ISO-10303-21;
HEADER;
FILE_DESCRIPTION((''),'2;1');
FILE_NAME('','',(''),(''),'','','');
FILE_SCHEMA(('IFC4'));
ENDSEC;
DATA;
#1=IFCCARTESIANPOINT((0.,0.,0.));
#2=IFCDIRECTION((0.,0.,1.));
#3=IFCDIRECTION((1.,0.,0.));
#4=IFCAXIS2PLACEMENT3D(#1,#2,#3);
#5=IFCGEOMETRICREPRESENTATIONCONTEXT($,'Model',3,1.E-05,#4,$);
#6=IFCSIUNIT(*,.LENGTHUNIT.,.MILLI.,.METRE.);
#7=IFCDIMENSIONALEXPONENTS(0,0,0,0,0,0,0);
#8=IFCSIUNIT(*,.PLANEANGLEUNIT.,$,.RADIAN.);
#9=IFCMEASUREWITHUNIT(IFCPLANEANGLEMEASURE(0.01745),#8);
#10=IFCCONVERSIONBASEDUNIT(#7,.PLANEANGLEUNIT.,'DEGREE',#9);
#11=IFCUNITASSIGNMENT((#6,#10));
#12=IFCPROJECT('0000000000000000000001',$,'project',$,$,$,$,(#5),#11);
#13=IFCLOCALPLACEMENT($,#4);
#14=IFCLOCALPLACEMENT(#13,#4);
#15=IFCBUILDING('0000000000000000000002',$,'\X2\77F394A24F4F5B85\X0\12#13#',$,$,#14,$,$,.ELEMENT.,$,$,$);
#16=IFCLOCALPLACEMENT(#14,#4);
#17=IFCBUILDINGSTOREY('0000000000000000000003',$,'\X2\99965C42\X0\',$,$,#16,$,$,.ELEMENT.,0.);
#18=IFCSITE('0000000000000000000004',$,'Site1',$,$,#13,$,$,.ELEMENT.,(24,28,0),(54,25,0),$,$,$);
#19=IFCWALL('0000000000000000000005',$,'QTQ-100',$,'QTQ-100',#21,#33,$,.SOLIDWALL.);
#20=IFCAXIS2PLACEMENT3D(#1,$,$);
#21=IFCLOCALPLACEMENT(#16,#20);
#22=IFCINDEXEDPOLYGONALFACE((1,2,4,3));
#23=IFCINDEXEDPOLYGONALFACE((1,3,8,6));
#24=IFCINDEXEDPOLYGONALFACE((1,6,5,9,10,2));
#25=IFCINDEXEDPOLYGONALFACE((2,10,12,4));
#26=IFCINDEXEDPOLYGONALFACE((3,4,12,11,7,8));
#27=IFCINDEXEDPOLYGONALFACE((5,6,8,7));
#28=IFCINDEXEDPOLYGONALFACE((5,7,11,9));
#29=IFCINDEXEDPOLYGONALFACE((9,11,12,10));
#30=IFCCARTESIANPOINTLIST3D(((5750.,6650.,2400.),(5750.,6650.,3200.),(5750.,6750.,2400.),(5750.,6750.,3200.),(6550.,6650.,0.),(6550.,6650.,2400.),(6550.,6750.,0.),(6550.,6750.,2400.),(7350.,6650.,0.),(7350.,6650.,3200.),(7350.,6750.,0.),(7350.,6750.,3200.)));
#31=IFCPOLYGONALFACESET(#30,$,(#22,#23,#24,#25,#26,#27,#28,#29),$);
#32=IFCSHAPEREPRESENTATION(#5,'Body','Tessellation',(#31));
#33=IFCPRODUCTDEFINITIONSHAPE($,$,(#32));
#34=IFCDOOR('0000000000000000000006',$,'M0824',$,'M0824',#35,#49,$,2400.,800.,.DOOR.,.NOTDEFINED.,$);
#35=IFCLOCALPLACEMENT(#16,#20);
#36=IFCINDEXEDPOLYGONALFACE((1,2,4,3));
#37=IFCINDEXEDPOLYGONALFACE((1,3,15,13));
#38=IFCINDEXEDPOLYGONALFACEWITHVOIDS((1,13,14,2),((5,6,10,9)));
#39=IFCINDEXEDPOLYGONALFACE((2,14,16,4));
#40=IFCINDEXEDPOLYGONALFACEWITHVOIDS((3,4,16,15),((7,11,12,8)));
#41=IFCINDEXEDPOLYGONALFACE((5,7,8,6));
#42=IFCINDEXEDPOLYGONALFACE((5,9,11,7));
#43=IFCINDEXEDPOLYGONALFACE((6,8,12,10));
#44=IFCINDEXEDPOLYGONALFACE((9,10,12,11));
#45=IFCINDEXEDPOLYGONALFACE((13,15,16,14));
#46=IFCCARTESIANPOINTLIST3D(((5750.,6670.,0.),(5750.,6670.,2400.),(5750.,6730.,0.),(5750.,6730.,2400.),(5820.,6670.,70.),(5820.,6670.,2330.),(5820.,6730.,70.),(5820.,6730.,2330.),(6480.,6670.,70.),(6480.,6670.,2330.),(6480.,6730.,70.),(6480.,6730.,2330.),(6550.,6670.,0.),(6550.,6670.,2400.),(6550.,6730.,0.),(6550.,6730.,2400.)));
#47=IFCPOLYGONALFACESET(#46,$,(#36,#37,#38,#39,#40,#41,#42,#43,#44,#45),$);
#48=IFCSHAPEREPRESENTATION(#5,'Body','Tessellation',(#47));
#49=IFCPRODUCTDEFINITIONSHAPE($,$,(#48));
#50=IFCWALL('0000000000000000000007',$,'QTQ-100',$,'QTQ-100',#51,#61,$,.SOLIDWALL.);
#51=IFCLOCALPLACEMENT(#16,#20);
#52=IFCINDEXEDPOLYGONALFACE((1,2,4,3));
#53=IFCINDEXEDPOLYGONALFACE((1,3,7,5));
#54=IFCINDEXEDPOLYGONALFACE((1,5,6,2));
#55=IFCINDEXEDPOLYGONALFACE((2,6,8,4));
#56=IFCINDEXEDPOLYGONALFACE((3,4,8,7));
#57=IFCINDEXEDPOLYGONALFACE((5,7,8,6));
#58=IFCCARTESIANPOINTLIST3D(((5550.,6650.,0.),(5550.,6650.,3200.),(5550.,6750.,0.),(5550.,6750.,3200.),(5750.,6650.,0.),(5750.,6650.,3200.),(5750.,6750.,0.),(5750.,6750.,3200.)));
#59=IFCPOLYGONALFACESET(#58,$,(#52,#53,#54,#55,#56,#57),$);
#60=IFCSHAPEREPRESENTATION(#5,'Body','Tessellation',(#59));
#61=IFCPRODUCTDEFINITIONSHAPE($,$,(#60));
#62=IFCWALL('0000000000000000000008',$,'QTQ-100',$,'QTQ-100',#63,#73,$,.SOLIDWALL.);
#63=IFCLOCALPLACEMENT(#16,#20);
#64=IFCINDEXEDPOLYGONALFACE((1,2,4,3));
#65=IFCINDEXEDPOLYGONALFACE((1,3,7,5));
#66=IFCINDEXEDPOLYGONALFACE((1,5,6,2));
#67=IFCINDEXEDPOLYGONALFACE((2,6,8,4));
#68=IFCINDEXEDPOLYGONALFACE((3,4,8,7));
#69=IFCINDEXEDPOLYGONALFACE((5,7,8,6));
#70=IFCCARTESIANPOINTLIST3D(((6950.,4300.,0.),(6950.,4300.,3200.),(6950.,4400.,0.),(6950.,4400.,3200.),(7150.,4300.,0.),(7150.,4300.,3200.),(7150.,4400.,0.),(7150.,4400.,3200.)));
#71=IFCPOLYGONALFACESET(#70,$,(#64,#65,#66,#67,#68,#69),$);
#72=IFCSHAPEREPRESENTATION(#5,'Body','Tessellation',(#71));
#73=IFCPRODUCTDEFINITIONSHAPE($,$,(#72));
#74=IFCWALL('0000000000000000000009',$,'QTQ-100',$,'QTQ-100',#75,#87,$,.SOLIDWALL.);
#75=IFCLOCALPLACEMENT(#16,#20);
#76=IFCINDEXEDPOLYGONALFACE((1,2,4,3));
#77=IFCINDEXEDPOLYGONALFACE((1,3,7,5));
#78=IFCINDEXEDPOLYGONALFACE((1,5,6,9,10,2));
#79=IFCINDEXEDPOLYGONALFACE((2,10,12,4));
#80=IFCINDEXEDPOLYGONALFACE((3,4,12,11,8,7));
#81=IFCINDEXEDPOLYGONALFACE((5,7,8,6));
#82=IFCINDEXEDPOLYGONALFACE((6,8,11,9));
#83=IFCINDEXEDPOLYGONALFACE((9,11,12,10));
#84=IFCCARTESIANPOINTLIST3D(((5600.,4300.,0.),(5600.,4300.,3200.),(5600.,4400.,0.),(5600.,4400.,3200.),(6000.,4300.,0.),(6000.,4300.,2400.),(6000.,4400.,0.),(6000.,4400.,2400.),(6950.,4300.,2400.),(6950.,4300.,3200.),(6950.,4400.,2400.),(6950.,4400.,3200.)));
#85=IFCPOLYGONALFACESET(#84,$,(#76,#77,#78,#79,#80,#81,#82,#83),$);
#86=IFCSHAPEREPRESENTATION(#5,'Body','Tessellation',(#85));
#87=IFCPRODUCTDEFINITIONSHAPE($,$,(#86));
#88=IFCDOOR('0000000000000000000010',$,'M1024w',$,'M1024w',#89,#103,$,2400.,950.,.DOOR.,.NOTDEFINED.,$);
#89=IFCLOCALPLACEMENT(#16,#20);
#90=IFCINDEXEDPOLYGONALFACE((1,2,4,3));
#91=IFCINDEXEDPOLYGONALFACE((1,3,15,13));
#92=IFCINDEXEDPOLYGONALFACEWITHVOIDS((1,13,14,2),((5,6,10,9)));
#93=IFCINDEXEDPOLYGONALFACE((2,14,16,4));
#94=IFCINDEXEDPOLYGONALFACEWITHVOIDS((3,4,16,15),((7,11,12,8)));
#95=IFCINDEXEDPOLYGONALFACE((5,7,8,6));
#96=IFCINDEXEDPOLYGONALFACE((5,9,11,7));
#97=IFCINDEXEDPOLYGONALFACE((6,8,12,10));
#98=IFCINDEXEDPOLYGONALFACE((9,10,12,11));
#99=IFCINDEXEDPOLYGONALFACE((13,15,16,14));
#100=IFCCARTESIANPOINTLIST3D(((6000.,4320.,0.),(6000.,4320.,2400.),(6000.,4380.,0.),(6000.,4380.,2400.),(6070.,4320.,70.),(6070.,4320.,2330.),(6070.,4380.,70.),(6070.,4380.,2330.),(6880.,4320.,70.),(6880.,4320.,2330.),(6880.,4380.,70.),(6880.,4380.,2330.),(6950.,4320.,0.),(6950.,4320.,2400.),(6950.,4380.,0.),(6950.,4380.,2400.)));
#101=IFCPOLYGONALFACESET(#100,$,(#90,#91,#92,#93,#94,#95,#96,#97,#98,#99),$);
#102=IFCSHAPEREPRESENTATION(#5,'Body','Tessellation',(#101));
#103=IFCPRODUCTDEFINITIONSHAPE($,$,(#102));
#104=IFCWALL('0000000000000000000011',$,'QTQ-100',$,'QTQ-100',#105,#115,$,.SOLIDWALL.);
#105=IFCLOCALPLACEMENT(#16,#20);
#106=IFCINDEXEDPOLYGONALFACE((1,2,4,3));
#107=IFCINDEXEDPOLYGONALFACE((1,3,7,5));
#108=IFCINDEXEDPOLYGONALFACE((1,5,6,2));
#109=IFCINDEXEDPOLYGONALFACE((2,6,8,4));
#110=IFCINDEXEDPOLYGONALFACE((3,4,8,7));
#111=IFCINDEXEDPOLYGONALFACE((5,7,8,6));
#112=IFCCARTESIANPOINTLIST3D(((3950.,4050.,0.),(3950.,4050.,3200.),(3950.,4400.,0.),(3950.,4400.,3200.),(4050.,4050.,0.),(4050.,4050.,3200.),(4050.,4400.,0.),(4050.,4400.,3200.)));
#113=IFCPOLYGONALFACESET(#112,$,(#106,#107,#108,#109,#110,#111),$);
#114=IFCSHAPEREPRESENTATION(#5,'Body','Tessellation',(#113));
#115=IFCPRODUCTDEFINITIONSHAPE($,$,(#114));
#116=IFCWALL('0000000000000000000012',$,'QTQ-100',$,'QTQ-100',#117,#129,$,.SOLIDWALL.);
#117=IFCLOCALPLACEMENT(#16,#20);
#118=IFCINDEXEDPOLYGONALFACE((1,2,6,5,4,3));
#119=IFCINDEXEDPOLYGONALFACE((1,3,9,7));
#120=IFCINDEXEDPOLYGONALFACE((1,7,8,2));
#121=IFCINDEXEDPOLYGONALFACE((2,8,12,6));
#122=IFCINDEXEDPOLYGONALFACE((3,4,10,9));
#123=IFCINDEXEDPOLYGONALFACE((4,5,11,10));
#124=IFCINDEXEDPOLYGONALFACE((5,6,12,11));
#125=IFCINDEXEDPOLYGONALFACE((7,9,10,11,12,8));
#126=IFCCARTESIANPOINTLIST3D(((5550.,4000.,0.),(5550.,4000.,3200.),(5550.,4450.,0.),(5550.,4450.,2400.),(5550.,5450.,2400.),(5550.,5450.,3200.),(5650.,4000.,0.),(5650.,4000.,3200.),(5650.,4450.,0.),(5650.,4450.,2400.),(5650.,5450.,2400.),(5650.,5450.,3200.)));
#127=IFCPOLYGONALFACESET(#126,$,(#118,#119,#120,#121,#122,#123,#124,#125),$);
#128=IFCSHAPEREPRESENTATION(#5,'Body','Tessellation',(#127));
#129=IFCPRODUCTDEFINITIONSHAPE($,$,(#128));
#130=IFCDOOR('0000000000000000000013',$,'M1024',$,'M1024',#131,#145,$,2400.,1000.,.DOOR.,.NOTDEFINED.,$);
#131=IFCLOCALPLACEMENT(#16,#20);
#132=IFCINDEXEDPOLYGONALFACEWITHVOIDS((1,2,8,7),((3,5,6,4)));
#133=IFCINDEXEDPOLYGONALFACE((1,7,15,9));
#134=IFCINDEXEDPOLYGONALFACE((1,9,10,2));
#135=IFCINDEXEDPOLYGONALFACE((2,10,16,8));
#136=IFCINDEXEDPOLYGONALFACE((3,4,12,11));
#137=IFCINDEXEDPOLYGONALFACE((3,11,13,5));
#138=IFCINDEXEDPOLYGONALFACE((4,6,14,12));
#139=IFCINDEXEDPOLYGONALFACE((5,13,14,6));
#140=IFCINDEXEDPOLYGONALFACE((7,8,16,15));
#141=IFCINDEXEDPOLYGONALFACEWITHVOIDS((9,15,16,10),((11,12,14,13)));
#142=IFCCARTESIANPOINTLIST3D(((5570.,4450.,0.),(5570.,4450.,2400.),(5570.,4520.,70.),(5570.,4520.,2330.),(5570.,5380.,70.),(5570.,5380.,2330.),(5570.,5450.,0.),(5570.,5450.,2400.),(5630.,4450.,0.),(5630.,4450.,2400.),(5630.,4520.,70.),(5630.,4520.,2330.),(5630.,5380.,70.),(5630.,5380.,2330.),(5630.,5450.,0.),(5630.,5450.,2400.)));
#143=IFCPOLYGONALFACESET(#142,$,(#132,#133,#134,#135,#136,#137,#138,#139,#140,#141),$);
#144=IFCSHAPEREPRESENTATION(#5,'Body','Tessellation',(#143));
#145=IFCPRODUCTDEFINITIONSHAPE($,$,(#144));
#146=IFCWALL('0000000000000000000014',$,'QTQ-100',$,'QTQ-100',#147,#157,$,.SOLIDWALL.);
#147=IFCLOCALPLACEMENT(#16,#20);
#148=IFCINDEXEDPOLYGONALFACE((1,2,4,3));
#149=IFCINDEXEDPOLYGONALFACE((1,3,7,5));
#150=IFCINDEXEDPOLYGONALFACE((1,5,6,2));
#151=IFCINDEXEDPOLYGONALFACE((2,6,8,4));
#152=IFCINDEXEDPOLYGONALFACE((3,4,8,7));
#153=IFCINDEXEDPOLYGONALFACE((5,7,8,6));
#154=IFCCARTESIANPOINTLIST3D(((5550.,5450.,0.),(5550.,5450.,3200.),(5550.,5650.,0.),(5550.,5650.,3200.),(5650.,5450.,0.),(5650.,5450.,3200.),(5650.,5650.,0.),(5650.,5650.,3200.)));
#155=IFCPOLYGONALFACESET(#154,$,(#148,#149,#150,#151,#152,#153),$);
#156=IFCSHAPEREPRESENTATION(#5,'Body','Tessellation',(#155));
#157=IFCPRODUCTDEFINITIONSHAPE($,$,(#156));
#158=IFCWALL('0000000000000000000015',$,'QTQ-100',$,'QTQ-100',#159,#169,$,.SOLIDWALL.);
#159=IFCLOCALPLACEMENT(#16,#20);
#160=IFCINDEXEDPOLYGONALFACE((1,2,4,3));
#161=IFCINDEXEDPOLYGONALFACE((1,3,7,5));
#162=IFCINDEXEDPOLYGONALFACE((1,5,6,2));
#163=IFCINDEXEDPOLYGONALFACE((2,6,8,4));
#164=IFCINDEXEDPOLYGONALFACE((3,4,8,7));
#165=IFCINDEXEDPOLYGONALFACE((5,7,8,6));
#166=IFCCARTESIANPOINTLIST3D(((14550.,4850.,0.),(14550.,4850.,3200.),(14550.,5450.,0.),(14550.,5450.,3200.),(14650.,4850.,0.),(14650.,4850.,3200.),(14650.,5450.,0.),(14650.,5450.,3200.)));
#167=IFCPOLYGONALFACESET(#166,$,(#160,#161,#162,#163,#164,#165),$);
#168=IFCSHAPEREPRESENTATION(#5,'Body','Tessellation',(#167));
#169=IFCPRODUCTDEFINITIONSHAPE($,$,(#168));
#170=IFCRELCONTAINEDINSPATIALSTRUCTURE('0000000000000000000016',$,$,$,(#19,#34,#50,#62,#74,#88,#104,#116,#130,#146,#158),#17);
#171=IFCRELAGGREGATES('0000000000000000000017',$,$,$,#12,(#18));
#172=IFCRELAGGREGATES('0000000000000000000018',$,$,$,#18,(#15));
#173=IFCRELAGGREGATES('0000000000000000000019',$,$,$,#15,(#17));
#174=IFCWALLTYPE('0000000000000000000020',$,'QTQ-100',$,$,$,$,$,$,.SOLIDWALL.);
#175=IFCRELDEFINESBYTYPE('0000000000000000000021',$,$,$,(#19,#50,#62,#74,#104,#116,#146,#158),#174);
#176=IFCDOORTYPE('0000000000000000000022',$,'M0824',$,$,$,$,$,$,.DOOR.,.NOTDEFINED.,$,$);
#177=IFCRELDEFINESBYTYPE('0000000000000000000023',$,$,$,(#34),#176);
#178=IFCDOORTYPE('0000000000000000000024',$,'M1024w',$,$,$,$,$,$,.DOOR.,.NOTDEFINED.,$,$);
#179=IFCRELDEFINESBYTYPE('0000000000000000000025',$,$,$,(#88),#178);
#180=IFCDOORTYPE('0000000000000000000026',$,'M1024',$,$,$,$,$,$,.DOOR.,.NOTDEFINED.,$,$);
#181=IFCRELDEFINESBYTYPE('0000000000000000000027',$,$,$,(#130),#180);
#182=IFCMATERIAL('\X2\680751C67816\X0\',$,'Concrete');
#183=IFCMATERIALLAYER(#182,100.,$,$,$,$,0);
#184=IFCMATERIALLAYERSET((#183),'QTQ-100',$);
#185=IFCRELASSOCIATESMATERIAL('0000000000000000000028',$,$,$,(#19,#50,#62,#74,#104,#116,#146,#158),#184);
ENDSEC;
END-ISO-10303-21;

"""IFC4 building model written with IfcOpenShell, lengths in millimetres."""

from ifc_helpers import new_model, entity, si_unit, converted_unit, frame, origin_with_axes, place, context, project, spatial, polyline, outline, extrude, material, layer, layer_set, type_object, element, fill, save


model = new_model("IFC4")

# Units and contexts
model_context = context("Model", 3, precision=1e-05, world=origin_with_axes())
ifc_project = project(units=[si_unit("LENGTHUNIT", "METRE", prefix="MILLI"), converted_unit("PLANEANGLEUNIT", "DEGREE", entity("IfcPlaneAngleMeasure", 0.01745), si_unit("PLANEANGLEUNIT", "RADIAN"), dimensions=[0, 0, 0, 0, 0, 0, 0])], contexts=[model_context])

# Site, building, storey
site_placement = place(None, origin_with_axes())
site = spatial("IfcSite", under=ifc_project, at=site_placement, Name="Site1", CompositionType="ELEMENT", RefLatitude=(24, 28, 0), RefLongitude=(54, 25, 0))
building_placement = place(site_placement, origin_with_axes())
building = spatial("IfcBuilding", under=site, at=building_placement, Name="石钢住宅12#13#", CompositionType="ELEMENT")
storey_placement = place(building_placement, origin_with_axes())
storey = spatial("IfcBuildingStorey", under=building, at=storey_placement, Name="首层", CompositionType="ELEMENT", Elevation=0.0)

# Shared definitions
ifc_material = material(Name="标准砖", Category="Concrete")
ifc_layer = layer(ifc_material, 100.0, Priority=0)
ifc_layer_set = layer_set([ifc_layer], Name="QTQ-100")
wall_type = type_object("IfcWallType", Name="QTQ-100", PredefinedType="SOLIDWALL")

# Wall, opening, door
wall_1_placement = place(storey_placement, origin_with_axes())
wall_1 = element("IfcWall", 1, at=wall_1_placement, inside=storey, type_object=wall_type, material=ifc_layer_set, Name="QTQ-100", ObjectType="QTQ-100", PredefinedType="SOLIDWALL", context=model_context, shape_type="SweptSolid", body=[
    extrude(outline(polyline([(0.0, 0.0), (3200.0, 0.0), (3200.0, 1600.0), (0.0, 1600.0), (0.0, 0.0)])), frame((5750.0, 6750.0, 3200.0), z_axis=(0.0, -1.0, 0.0), x_axis=(0.0, 0.0, -1.0)), (0.0, 0.0, 1.0), 100.0),
])
opening_1_placement = place(storey_placement, origin_with_axes())
opening_1 = element("IfcOpeningElement", 2, at=opening_1_placement, cuts=wall_1, PredefinedType="OPENING", context=model_context, shape_type="SweptSolid", body=[
    extrude(outline(polyline([(0.0, 0.0), (800.0, 0.0), (800.0, 2400.0), (0.0, 2400.0), (0.0, 0.0)])), frame((5750.0, 7750.0, 0.0), z_axis=(0.0, -1.0, 0.0), x_axis=(1.0, 0.0, 0.0)), (0.0, 0.0, 1.0), 2100.0),
])
door_type_1 = type_object("IfcDoorType", Name="M0824", OperationType="NOTDEFINED", PredefinedType="DOOR")
door_1_placement = place(storey_placement, origin_with_axes())
door_1 = element("IfcDoor", 3, at=door_1_placement, inside=storey, type_object=door_type_1, Name="M0824", ObjectType="M0824", OperationType="NOTDEFINED", OverallHeight=2400.0, OverallWidth=800.0, PredefinedType="DOOR", context=model_context, shape_type="SweptSolid", body=[
    extrude(outline(polyline([(-400.0, -1200.0), (400.0, -1200.0), (400.0, 1200.0), (-400.0, 1200.0), (-400.0, -1200.0)]), holes=[polyline([(-330.0, -1130.0), (-330.0, 1130.0), (330.0, 1130.0), (330.0, -1130.0), (-330.0, -1130.0)])]), frame((6150.0, 6730.0, 1200.0), z_axis=(0.0, -1.0, 0.0), x_axis=(1.0, 0.0, 0.0)), (0.0, 0.0, 1.0), 60.0),
])
fill(opening_1, door_1)

# Walls
wall_2_placement = place(storey_placement, origin_with_axes())
element("IfcWall", 4, at=wall_2_placement, inside=storey, type_object=wall_type, material=ifc_layer_set, Name="QTQ-100", ObjectType="QTQ-100", PredefinedType="SOLIDWALL", context=model_context, shape_type="SweptSolid", body=[
    extrude(outline(polyline([(0.0, 0.0), (3200.0, 0.0), (3200.0, 200.0), (0.0, 200.0), (0.0, 0.0)])), frame((5550.0, 6750.0, 3200.0), z_axis=(0.0, -1.0, 0.0), x_axis=(0.0, 0.0, -1.0)), (0.0, 0.0, 1.0), 100.0),
])
wall_3_placement = place(storey_placement, origin_with_axes())
element("IfcWall", 5, at=wall_3_placement, inside=storey, type_object=wall_type, material=ifc_layer_set, Name="QTQ-100", ObjectType="QTQ-100", PredefinedType="SOLIDWALL", context=model_context, shape_type="SweptSolid", body=[
    extrude(outline(polyline([(0.0, 0.0), (3200.0, 0.0), (3200.0, 200.0), (0.0, 200.0), (0.0, 0.0)])), frame((6950.0, 4400.0, 3200.0), z_axis=(0.0, -1.0, 0.0), x_axis=(0.0, 0.0, -1.0)), (0.0, 0.0, 1.0), 100.0),
])

# Wall, opening, door
wall_4_placement = place(storey_placement, origin_with_axes())
wall_4 = element("IfcWall", 6, at=wall_4_placement, inside=storey, type_object=wall_type, material=ifc_layer_set, Name="QTQ-100", ObjectType="QTQ-100", PredefinedType="SOLIDWALL", context=model_context, shape_type="SweptSolid", body=[
    extrude(outline(polyline([(0.0, 0.0), (3200.0, 0.0), (3200.0, 1350.0), (0.0, 1350.0), (0.0, 0.0)])), frame((5600.0, 4400.0, 3200.0), z_axis=(0.0, -1.0, 0.0), x_axis=(0.0, 0.0, -1.0)), (0.0, 0.0, 1.0), 100.0),
])
opening_2_placement = place(storey_placement, origin_with_axes())
opening_2 = element("IfcOpeningElement", 7, at=opening_2_placement, cuts=wall_4, PredefinedType="OPENING", context=model_context, shape_type="SweptSolid", body=[
    extrude(outline(polyline([(0.0, 0.0), (950.0, 0.0), (950.0, 2400.0), (0.0, 2400.0), (0.0, 0.0)])), frame((6000.0, 5400.0, 0.0), z_axis=(0.0, -1.0, 0.0), x_axis=(1.0, 0.0, 0.0)), (0.0, 0.0, 1.0), 2100.0),
])
door_type_2 = type_object("IfcDoorType", Name="M1024w", OperationType="NOTDEFINED", PredefinedType="DOOR")
door_2_placement = place(storey_placement, origin_with_axes())
door_2 = element("IfcDoor", 8, at=door_2_placement, inside=storey, type_object=door_type_2, Name="M1024w", ObjectType="M1024w", OperationType="NOTDEFINED", OverallHeight=2400.0, OverallWidth=950.0, PredefinedType="DOOR", context=model_context, shape_type="SweptSolid", body=[
    extrude(outline(polyline([(-475.0, -1200.0), (475.0, -1200.0), (475.0, 1200.0), (-475.0, 1200.0), (-475.0, -1200.0)]), holes=[polyline([(-405.0, -1130.0), (-405.0, 1130.0), (405.0, 1130.0), (405.0, -1130.0), (-405.0, -1130.0)])]), frame((6475.0, 4380.0, 1200.0), z_axis=(0.0, -1.0, 0.0), x_axis=(1.0, 0.0, 0.0)), (0.0, 0.0, 1.0), 60.0),
])
fill(opening_2, door_2)

# Wall
wall_5_placement = place(storey_placement, origin_with_axes())
element("IfcWall", 9, at=wall_5_placement, inside=storey, type_object=wall_type, material=ifc_layer_set, Name="QTQ-100", ObjectType="QTQ-100", PredefinedType="SOLIDWALL", context=model_context, shape_type="SweptSolid", body=[
    extrude(outline(polyline([(0.0, 0.0), (3200.0, 0.0), (3200.0, 350.0), (0.0, 350.0), (0.0, 0.0)])), frame((3950.0, 4050.0, 3200.0), z_axis=(1.0, 0.0, 0.0), x_axis=(0.0, 0.0, -1.0)), (0.0, 0.0, 1.0), 100.0),
])

# Wall, opening, door
wall_6_placement = place(storey_placement, origin_with_axes())
wall_6 = element("IfcWall", 10, at=wall_6_placement, inside=storey, type_object=wall_type, material=ifc_layer_set, Name="QTQ-100", ObjectType="QTQ-100", PredefinedType="SOLIDWALL", context=model_context, shape_type="SweptSolid", body=[
    extrude(outline(polyline([(0.0, 0.0), (3200.0, 0.0), (3200.0, 1450.0), (0.0, 1450.0), (0.0, 0.0)])), frame((5650.0, 5450.0, 3200.0), z_axis=(-1.0, 0.0, 0.0), x_axis=(0.0, 0.0, -1.0)), (0.0, 0.0, 1.0), 100.0),
])
opening_3_placement = place(storey_placement, origin_with_axes())
opening_3 = element("IfcOpeningElement", 11, at=opening_3_placement, cuts=wall_6, PredefinedType="OPENING", context=model_context, shape_type="SweptSolid", body=[
    extrude(outline(polyline([(0.0, 0.0), (1000.0, 0.0), (1000.0, 2400.0), (0.0, 2400.0), (0.0, 0.0)])), frame((6650.0, 5450.0, 0.0), z_axis=(-1.0, 0.0, 0.0), x_axis=(0.0, -1.0, 0.0)), (0.0, 0.0, 1.0), 2100.0),
])
door_type_3 = type_object("IfcDoorType", Name="M1024", OperationType="NOTDEFINED", PredefinedType="DOOR")
door_3_placement = place(storey_placement, origin_with_axes())
door_3 = element("IfcDoor", 12, at=door_3_placement, inside=storey, type_object=door_type_3, Name="M1024", ObjectType="M1024", OperationType="NOTDEFINED", OverallHeight=2400.0, OverallWidth=1000.0, PredefinedType="DOOR", context=model_context, shape_type="SweptSolid", body=[
    extrude(outline(polyline([(-500.0, -1200.0), (500.0, -1200.0), (500.0, 1200.0), (-500.0, 1200.0), (-500.0, -1200.0)]), holes=[polyline([(-430.0, -1130.0), (-430.0, 1130.0), (430.0, 1130.0), (430.0, -1130.0), (-430.0, -1130.0)])]), frame((5630.0, 4950.0, 1200.0), z_axis=(-1.0, 0.0, 0.0), x_axis=(0.0, -1.0, 0.0)), (0.0, 0.0, 1.0), 60.0),
])
fill(opening_3, door_3)

# Walls
wall_7_placement = place(storey_placement, origin_with_axes())
element("IfcWall", 13, at=wall_7_placement, inside=storey, type_object=wall_type, material=ifc_layer_set, Name="QTQ-100", ObjectType="QTQ-100", PredefinedType="SOLIDWALL", context=model_context, shape_type="SweptSolid", body=[
    extrude(outline(polyline([(0.0, 0.0), (3200.0, 0.0), (3200.0, 200.0), (0.0, 200.0), (0.0, 0.0)])), frame((5650.0, 5650.0, 3200.0), z_axis=(-1.0, 0.0, 0.0), x_axis=(0.0, 0.0, -1.0)), (0.0, 0.0, 1.0), 100.0),
])
wall_8_placement = place(storey_placement, origin_with_axes())
element("IfcWall", 14, at=wall_8_placement, inside=storey, type_object=wall_type, material=ifc_layer_set, Name="QTQ-100", ObjectType="QTQ-100", PredefinedType="SOLIDWALL", context=model_context, shape_type="SweptSolid", body=[
    extrude(outline(polyline([(0.0, 0.0), (3200.0, 0.0), (3200.0, 600.0), (0.0, 600.0), (0.0, 0.0)])), frame((14550.0, 4850.0, 3200.0), z_axis=(1.0, 0.0, 0.0), x_axis=(0.0, 0.0, -1.0)), (0.0, 0.0, 1.0), 100.0),
])

save(model, "model.ifc")
